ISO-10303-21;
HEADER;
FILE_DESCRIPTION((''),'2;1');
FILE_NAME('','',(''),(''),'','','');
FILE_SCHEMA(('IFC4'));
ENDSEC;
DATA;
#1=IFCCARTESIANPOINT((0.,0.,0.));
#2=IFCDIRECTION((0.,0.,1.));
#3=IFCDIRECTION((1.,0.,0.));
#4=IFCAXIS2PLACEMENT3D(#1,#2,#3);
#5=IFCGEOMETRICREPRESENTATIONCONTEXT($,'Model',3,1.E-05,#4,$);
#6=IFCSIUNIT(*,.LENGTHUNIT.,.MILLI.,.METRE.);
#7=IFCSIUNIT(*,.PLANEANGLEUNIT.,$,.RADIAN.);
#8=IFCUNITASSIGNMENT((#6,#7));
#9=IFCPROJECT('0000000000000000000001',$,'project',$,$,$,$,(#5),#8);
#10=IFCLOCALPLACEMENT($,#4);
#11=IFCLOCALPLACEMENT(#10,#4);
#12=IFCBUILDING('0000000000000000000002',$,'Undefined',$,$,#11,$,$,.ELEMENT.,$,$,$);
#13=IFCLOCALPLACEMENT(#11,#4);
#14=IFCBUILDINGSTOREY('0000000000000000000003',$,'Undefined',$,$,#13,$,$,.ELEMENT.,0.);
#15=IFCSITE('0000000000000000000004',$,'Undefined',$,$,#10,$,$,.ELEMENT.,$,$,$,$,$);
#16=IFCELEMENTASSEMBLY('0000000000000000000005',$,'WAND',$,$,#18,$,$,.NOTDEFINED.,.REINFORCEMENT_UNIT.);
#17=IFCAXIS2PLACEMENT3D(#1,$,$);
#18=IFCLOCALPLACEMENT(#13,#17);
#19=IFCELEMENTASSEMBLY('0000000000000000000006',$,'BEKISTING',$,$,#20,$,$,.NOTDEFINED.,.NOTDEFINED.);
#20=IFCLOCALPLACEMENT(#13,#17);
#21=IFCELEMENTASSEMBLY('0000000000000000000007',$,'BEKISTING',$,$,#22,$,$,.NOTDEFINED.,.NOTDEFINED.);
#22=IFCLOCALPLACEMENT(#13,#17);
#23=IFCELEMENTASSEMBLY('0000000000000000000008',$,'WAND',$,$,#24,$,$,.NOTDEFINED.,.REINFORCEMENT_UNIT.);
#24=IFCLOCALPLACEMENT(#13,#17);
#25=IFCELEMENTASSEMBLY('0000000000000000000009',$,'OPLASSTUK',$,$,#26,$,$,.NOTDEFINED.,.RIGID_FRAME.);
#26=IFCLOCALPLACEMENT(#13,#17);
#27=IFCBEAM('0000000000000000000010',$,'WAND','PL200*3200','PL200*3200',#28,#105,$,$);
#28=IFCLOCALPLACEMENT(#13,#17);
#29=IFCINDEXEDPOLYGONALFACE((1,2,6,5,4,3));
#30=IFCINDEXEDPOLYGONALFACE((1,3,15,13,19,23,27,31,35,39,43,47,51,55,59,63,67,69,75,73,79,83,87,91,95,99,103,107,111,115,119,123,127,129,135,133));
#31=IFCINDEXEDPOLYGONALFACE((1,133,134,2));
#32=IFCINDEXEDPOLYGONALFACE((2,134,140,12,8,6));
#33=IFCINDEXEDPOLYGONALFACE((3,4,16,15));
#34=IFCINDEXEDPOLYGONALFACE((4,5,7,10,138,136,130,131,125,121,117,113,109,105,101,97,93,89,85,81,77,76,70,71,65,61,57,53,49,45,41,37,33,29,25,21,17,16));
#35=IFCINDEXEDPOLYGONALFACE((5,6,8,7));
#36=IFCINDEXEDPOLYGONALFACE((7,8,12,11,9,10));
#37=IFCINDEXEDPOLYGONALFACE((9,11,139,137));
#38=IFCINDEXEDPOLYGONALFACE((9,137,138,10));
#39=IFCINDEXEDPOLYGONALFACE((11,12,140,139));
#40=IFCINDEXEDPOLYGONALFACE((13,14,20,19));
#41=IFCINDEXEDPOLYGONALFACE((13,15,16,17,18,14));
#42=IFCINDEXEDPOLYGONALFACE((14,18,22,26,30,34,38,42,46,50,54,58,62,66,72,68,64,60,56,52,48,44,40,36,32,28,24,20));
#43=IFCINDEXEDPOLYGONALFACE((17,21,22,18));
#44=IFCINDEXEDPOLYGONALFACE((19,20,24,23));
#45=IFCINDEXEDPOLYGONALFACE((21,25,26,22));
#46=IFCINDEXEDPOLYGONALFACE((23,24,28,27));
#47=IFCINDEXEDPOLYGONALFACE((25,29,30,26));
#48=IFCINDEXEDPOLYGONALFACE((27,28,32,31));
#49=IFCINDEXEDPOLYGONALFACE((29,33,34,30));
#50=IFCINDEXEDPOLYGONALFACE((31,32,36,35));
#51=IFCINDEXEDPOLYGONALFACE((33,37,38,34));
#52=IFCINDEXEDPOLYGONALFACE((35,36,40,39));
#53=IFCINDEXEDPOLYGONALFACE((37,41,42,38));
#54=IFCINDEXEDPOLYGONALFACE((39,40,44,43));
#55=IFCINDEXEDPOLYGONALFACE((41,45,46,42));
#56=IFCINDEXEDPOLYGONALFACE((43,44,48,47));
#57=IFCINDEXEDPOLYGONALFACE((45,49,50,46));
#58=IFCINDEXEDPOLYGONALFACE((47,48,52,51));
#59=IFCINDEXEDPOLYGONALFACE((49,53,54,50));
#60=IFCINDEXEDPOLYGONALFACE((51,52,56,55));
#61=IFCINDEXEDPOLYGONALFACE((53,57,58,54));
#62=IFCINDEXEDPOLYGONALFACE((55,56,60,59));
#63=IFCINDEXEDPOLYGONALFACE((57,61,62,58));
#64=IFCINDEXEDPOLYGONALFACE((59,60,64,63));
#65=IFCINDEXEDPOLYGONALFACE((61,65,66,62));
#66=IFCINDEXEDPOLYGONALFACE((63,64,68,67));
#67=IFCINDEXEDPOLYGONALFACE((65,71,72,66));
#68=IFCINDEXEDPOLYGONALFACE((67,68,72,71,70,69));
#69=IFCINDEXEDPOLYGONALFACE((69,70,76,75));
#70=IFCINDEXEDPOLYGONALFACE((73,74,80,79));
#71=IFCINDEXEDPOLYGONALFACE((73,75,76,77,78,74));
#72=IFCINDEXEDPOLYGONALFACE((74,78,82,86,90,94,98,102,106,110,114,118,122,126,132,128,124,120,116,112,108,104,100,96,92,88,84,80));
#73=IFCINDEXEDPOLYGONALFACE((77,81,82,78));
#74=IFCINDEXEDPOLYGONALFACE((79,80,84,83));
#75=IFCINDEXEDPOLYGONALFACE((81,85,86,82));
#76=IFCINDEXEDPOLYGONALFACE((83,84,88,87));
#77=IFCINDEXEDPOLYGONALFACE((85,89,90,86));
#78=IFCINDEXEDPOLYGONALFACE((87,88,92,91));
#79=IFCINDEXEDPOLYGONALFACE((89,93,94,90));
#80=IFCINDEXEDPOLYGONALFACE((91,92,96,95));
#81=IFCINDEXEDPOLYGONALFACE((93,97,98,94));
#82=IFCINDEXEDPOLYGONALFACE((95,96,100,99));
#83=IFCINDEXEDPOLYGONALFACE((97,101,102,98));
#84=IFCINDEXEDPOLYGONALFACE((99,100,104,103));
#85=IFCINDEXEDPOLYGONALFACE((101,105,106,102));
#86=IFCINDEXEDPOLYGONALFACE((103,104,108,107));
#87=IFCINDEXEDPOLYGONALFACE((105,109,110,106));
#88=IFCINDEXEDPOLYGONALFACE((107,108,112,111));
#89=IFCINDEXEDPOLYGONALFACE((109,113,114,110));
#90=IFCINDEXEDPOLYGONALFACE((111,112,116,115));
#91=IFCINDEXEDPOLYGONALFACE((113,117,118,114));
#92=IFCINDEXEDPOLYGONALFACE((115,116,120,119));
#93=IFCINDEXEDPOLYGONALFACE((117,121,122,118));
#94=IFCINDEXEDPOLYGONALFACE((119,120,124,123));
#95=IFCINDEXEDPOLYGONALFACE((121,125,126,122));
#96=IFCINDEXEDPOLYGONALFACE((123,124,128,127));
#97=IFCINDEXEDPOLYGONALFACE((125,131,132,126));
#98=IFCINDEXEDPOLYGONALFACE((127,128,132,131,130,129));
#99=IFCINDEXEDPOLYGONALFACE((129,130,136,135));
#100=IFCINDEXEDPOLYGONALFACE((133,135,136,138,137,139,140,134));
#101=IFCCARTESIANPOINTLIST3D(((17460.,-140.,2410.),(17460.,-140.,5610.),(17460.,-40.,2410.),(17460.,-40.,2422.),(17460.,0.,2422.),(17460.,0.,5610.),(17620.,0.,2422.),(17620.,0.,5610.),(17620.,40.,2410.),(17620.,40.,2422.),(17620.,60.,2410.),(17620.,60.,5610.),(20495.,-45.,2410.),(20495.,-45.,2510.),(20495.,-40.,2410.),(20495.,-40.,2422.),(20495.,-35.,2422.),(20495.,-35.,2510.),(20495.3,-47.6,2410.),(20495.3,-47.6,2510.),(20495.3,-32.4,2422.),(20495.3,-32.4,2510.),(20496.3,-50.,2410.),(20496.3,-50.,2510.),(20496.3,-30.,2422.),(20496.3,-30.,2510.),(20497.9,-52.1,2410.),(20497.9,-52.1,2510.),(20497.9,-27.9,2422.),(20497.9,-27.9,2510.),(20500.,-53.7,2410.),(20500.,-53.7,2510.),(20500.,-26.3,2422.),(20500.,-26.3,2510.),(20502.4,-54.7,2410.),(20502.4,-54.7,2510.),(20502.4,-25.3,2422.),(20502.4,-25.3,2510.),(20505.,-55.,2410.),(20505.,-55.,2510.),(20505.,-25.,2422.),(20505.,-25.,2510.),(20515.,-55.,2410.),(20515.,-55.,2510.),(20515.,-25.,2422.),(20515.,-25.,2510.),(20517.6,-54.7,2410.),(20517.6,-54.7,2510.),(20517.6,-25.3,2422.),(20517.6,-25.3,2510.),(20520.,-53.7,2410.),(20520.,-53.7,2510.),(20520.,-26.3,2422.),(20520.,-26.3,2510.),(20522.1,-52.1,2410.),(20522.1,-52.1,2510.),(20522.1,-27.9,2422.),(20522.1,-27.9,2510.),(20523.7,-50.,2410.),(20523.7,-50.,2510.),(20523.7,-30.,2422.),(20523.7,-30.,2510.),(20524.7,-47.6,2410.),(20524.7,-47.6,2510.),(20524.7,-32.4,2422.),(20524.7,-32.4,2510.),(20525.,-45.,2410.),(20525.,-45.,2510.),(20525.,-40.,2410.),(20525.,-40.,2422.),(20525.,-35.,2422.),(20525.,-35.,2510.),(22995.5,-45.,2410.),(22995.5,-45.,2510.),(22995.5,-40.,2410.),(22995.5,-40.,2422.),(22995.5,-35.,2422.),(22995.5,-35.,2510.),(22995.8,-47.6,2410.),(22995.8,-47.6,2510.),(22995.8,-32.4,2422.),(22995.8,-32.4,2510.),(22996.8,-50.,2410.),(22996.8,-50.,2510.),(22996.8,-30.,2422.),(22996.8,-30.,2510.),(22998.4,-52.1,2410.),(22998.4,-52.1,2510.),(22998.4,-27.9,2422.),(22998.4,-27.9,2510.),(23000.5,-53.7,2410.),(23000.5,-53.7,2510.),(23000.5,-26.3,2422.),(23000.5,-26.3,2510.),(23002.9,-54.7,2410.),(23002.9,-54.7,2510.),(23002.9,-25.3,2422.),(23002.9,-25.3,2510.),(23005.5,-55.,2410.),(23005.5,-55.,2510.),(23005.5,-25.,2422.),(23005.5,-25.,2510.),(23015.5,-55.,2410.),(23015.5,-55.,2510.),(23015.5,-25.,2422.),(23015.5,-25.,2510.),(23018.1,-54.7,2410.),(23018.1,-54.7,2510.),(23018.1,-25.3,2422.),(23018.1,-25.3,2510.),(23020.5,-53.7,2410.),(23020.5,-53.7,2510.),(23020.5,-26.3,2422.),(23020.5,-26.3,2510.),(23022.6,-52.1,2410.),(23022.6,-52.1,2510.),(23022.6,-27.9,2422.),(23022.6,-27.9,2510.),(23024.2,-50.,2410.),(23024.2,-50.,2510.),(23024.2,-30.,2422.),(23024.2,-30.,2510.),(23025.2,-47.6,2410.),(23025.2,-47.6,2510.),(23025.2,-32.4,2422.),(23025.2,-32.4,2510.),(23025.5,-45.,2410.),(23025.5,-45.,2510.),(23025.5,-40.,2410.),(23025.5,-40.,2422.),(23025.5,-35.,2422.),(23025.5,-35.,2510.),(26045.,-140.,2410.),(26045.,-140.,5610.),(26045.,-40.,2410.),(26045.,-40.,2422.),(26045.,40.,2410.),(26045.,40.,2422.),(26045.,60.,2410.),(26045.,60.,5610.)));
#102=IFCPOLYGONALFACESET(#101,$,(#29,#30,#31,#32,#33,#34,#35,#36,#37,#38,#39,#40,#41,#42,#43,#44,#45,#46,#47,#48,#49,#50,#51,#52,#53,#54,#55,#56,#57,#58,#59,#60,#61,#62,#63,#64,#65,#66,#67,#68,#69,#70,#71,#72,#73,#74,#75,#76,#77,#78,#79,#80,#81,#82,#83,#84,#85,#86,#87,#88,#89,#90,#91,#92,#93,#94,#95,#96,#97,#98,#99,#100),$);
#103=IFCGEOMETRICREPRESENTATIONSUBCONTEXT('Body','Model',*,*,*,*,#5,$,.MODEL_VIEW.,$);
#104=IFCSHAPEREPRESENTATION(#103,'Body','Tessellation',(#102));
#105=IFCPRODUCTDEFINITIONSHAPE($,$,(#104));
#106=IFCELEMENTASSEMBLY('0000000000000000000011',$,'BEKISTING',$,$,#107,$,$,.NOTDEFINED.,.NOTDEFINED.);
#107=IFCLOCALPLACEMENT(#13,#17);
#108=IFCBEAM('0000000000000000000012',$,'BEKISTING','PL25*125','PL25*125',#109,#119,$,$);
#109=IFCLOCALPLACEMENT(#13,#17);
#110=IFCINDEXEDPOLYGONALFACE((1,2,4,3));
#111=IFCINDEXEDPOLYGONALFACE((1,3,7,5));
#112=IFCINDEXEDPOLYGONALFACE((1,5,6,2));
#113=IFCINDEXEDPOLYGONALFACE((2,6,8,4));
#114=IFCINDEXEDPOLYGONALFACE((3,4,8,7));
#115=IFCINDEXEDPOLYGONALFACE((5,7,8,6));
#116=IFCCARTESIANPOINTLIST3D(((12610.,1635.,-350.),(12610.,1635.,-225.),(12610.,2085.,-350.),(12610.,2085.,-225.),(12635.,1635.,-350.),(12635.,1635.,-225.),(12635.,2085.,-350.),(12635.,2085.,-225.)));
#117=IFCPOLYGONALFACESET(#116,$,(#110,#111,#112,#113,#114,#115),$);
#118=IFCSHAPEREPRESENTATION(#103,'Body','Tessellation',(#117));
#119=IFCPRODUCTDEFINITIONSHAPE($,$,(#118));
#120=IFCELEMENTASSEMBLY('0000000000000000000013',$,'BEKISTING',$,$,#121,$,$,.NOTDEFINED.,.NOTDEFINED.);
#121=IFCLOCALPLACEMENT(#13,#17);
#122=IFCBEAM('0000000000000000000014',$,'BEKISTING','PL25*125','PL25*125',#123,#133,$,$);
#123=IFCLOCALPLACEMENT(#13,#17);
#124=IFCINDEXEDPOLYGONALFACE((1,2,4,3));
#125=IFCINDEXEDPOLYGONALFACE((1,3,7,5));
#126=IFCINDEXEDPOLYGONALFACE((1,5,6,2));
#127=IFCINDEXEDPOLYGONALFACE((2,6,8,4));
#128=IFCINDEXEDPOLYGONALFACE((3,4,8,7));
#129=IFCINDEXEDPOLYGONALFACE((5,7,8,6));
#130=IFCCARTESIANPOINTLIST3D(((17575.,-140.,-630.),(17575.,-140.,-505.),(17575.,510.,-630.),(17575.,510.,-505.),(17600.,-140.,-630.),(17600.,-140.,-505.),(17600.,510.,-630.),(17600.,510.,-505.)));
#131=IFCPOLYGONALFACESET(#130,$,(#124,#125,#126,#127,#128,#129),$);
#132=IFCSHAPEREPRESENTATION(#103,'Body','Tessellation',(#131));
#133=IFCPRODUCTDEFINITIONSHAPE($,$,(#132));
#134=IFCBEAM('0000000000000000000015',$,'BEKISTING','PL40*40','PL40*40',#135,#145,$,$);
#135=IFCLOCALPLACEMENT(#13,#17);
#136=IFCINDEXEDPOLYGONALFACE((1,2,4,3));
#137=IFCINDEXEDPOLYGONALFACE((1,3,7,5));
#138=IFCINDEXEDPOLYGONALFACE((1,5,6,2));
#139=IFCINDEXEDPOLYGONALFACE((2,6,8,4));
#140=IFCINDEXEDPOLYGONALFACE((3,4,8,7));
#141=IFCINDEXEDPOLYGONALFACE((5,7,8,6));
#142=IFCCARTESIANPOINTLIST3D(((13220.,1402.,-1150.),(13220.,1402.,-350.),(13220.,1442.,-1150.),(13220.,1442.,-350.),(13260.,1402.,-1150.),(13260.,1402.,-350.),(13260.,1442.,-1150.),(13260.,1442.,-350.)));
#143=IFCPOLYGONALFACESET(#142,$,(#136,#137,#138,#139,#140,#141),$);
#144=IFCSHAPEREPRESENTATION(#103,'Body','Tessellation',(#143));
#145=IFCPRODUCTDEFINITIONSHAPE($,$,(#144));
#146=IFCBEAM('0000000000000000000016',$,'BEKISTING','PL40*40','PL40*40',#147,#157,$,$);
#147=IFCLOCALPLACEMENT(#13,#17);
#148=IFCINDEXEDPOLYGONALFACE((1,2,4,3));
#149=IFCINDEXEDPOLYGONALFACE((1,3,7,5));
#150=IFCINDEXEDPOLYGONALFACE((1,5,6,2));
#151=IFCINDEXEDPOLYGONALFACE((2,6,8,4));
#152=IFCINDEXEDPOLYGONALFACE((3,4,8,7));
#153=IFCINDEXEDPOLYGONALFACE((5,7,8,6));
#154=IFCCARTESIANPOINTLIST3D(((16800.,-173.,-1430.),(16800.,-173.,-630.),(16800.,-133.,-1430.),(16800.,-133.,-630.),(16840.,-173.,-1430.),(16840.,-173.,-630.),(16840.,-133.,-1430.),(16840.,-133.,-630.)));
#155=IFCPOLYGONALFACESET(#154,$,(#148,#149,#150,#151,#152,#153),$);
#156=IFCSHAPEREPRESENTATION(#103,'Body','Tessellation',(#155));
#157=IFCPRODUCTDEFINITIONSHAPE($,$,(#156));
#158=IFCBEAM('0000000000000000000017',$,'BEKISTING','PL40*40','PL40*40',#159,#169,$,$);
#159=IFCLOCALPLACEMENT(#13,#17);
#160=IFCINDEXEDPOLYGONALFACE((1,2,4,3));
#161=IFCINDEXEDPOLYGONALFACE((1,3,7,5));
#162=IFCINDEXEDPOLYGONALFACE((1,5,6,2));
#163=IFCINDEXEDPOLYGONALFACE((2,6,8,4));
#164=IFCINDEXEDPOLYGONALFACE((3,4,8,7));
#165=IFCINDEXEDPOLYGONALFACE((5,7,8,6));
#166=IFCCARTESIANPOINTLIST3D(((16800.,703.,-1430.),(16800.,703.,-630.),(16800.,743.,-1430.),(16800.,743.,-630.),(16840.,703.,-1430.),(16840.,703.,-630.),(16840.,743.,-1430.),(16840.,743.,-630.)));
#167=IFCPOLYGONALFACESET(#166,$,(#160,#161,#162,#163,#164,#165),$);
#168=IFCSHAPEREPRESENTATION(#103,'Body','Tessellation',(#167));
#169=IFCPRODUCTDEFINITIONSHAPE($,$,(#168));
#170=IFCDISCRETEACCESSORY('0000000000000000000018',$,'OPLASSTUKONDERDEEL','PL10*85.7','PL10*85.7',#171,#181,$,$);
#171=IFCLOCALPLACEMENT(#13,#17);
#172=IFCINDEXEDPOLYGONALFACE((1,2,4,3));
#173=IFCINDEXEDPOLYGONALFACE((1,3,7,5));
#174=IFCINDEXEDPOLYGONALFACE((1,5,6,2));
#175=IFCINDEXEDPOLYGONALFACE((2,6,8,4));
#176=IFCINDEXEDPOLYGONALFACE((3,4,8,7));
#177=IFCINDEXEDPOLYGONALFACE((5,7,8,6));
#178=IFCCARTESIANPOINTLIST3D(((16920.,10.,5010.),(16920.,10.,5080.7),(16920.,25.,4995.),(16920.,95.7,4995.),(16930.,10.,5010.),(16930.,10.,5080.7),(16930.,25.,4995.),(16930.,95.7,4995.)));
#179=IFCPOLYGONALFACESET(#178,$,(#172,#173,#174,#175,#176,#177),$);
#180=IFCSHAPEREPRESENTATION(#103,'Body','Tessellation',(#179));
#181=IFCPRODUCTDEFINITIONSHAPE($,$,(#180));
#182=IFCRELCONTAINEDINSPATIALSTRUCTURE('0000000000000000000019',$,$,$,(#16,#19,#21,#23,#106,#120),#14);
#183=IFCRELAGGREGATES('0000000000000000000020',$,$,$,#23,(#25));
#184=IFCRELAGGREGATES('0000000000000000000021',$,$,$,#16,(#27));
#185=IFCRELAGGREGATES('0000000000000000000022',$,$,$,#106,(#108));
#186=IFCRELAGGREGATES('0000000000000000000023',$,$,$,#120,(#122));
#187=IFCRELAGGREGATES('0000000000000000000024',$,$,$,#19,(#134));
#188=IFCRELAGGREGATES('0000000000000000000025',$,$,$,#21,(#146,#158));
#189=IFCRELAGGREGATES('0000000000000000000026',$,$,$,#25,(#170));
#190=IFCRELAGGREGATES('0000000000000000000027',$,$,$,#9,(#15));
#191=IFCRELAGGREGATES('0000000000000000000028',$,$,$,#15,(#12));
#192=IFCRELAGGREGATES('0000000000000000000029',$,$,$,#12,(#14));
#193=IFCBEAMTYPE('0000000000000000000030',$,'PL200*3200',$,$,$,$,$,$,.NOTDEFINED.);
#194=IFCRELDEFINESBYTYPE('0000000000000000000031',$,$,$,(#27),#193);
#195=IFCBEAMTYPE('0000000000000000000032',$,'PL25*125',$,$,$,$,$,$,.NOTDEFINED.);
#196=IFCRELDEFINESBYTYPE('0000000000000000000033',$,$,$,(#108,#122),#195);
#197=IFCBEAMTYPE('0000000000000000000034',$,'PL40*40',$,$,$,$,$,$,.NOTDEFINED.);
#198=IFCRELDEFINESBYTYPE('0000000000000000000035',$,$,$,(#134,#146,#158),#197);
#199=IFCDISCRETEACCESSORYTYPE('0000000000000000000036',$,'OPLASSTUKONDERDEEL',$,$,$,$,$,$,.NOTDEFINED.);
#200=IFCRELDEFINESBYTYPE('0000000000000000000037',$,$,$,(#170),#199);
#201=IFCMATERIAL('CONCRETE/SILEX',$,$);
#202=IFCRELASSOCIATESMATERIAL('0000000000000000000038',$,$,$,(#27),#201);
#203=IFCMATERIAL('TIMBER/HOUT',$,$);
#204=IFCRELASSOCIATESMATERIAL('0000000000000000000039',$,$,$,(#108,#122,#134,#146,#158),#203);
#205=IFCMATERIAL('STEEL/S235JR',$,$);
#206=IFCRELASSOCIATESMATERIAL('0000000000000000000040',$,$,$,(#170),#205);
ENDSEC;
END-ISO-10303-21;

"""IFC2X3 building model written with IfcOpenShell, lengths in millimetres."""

from ifc_helpers import new_model, si_unit, frame, frame_2d, origin_with_axes, place, context, subcontext, project, spatial, polyline, circle_curve, parameter, trimmed, segment, composite_curve, rectangle, outline, extrude, boolean, material, type_object, element, aggregate, save


model = new_model("IFC2X3")

# Units and contexts
model_context = context("Model", 3, precision=1e-05, world=origin_with_axes())
body_context = subcontext(model_context, "Body", "Model", "MODEL_VIEW")
ifc_project = project(units=[si_unit("LENGTHUNIT", "METRE", prefix="MILLI"), si_unit("PLANEANGLEUNIT", "RADIAN")], contexts=[model_context])

# Site, building, storey
site_placement = place(None, origin_with_axes())
site = spatial("IfcSite", under=ifc_project, at=site_placement, Name="Undefined", CompositionType="ELEMENT")
building_placement = place(site_placement, origin_with_axes())
building = spatial("IfcBuilding", under=site, at=building_placement, Name="Undefined", CompositionType="ELEMENT")
storey_placement = place(building_placement, origin_with_axes())
storey = spatial("IfcBuildingStorey", under=building, at=storey_placement, Name="Undefined", CompositionType="ELEMENT", Elevation=0.0)

# Shared definitions
ifc_material_1 = material(Name="CONCRETE/SILEX")

# Element assembly
assembly_1_placement = place(storey_placement, origin_with_axes())
assembly_1 = element("IfcElementAssembly", 1, at=assembly_1_placement, inside=storey, Name="WAND", AssemblyPlace="NOTDEFINED", PredefinedType="REINFORCEMENT_UNIT")

# Element assemblies
ifc_material_2 = material(Name="STEEL/S235JR")
assembly_2_placement = place(storey_placement, origin_with_axes())
assembly_2 = element("IfcElementAssembly", 2, at=assembly_2_placement, inside=storey, Name="BEKISTING", AssemblyPlace="NOTDEFINED", PredefinedType="NOTDEFINED")
ifc_material_3 = material(Name="TIMBER/HOUT")
assembly_3_placement = place(storey_placement, origin_with_axes())
assembly_3 = element("IfcElementAssembly", 3, at=assembly_3_placement, inside=storey, Name="BEKISTING", AssemblyPlace="NOTDEFINED", PredefinedType="NOTDEFINED")

# Element assemblies
assembly_4_placement = place(storey_placement, origin_with_axes())
assembly_4 = element("IfcElementAssembly", 4, at=assembly_4_placement, inside=storey, Name="WAND", AssemblyPlace="NOTDEFINED", PredefinedType="REINFORCEMENT_UNIT")
assembly_5_placement = place(assembly_4_placement, origin_with_axes())
assembly_5 = element("IfcElementAssembly", 5, at=assembly_5_placement, Name="OPLASSTUK", AssemblyPlace="NOTDEFINED", PredefinedType="RIGID_FRAME")
aggregate(assembly_4, [assembly_5])

# Beam
beam_type_1 = type_object("IfcBeamType", Name="PL200*3200", PredefinedType="NOTDEFINED")
beam_1_placement = place(assembly_1_placement, frame((17460.0, -40.0, 4010.0), z_axis=(0.0, 0.0, 1.0), x_axis=(1.0, 0.0, 0.0)))
beam_1 = element("IfcBeam", 6, at=beam_1_placement, type_object=beam_type_1, material=ifc_material_1, Name="WAND", Description="PL200*3200", ObjectType="PL200*3200", context=body_context, shape_type="CSG", body=[
    boolean("DIFFERENCE", boolean("DIFFERENCE", boolean("DIFFERENCE", boolean("DIFFERENCE", extrude(rectangle(XDim=200.0, YDim=3200.0, at=frame_2d((0.0, 0.0), x_axis=(1.0, 0.0))), frame((8585.0, 0.0, 0.0), z_axis=(-1.0, 0.0, 0.0), x_axis=(0.0, -1.0, 0.0)), (0.0, 0.0, 1.0), 8585.0), extrude(outline(composite_curve([segment(trimmed(circle_curve(frame_2d((10.0, 10.0), x_axis=(-1.0, 0.0)), 10.0), [parameter(0.0)], [parameter(1.570796)], True, "PARAMETER"), True, "CONTINUOUS"), segment(polyline([(10.0, 0.0), (20.0, 0.0)]), True, "CONTINUOUS"), segment(trimmed(circle_curve(frame_2d((20.0, 10.0), x_axis=(0.0, -1.0)), 10.0), [parameter(0.0)], [parameter(1.570796)], True, "PARAMETER"), True, "CONTINUOUS"), segment(polyline([(30.0, 10.0), (30.0, 20.0)]), True, "CONTINUOUS"), segment(trimmed(circle_curve(frame_2d((20.0, 20.0), x_axis=(1.0, 0.0)), 10.0), [parameter(0.0)], [parameter(1.570796)], True, "PARAMETER"), True, "CONTINUOUS"), segment(polyline([(20.0, 30.0), (10.0, 30.0)]), True, "CONTINUOUS"), segment(trimmed(circle_curve(frame_2d((10.0, 20.0), x_axis=(0.0, 1.0)), 10.0), [parameter(0.0)], [parameter(1.570796)], True, "PARAMETER"), True, "CONTINUOUS"), segment(polyline([(0.0, 20.0), (0.0, 10.0)]), True, "CONTINUOUS")], self_intersect=True)), frame((3035.0, 15.0, -1600.0), z_axis=(0.0, 0.0, 1.0), x_axis=(0.0, -1.0, 0.0)), (0.0, 0.0, 1.0), 100.0)), extrude(outline(composite_curve([segment(trimmed(circle_curve(frame_2d((10.0, 10.0), x_axis=(-1.0, 0.0)), 10.0), [parameter(0.0)], [parameter(1.570796)], True, "PARAMETER"), True, "CONTINUOUS"), segment(polyline([(10.0, 0.0), (20.0, 0.0)]), True, "CONTINUOUS"), segment(trimmed(circle_curve(frame_2d((20.0, 10.0), x_axis=(0.0, -1.0)), 10.0), [parameter(0.0)], [parameter(1.570796)], True, "PARAMETER"), True, "CONTINUOUS"), segment(polyline([(30.0, 10.0), (30.0, 20.0)]), True, "CONTINUOUS"), segment(trimmed(circle_curve(frame_2d((20.0, 20.0), x_axis=(1.0, 0.0)), 10.0), [parameter(0.0)], [parameter(1.570796)], True, "PARAMETER"), True, "CONTINUOUS"), segment(polyline([(20.0, 30.0), (10.0, 30.0)]), True, "CONTINUOUS"), segment(trimmed(circle_curve(frame_2d((10.0, 20.0), x_axis=(0.0, 1.0)), 10.0), [parameter(0.0)], [parameter(1.570796)], True, "PARAMETER"), True, "CONTINUOUS"), segment(polyline([(0.0, 20.0), (0.0, 10.0)]), True, "CONTINUOUS")], self_intersect=True)), frame((5565.5, -15.0, -1600.0), z_axis=(0.0, 0.0, 1.0), x_axis=(0.0, 1.0, 0.0)), (0.0, 0.0, 1.0), 100.0)), extrude(outline(polyline([(0.0, 0.0), (60.0, 0.0), (60.0, 185.3), (0.0, 185.3), (0.0, 0.0)])), frame((160.0, 100.0, 1603.0), z_axis=(0.0, 0.0, -1.0), x_axis=(0.0, -1.0, 0.0)), (0.0, 0.0, 1.0), 3205.0)), extrude(rectangle(XDim=12.0, YDim=80.0, at=frame_2d((0.0, 0.0), x_axis=(1.0, 0.0))), frame((8585.0, 40.0, -1594.0), z_axis=(-1.0, 0.0, 0.0), x_axis=(0.0, 0.0, -1.0)), (0.0, 0.0, 1.0), 8585.0)),
])
aggregate(assembly_1, [beam_1])

# Element assemblies, beams
assembly_6_placement = place(storey_placement, origin_with_axes())
assembly_6 = element("IfcElementAssembly", 7, at=assembly_6_placement, inside=storey, Name="BEKISTING", AssemblyPlace="NOTDEFINED", PredefinedType="NOTDEFINED")
beam_type_2 = type_object("IfcBeamType", Name="PL25*125", PredefinedType="NOTDEFINED")
beam_2_placement = place(assembly_6_placement, frame((12622.5, 1635.0, -287.5), z_axis=(0.0, 0.0, 1.0), x_axis=(0.0, 1.0, 0.0)))
beam_2 = element("IfcBeam", 8, at=beam_2_placement, type_object=beam_type_2, material=ifc_material_3, Name="BEKISTING", Description="PL25*125", ObjectType="PL25*125", context=body_context, shape_type="SweptSolid", body=[
    extrude(rectangle(XDim=25.0, YDim=125.0, at=frame_2d((0.0, 0.0), x_axis=(1.0, 0.0))), frame((450.0, 0.0, 0.0), z_axis=(-1.0, 0.0, 0.0), x_axis=(0.0, -1.0, 0.0)), (0.0, 0.0, 1.0), 450.0),
])
aggregate(assembly_6, [beam_2])
assembly_7_placement = place(storey_placement, origin_with_axes())
assembly_7 = element("IfcElementAssembly", 9, at=assembly_7_placement, inside=storey, Name="BEKISTING", AssemblyPlace="NOTDEFINED", PredefinedType="NOTDEFINED")
beam_3_placement = place(assembly_7_placement, frame((17587.5, -140.0, -567.5), z_axis=(0.0, 0.0, -1.0), x_axis=(0.0, 1.0, 0.0)))
beam_3 = element("IfcBeam", 10, at=beam_3_placement, type_object=beam_type_2, material=ifc_material_3, Name="BEKISTING", Description="PL25*125", ObjectType="PL25*125", context=body_context, shape_type="SweptSolid", body=[
    extrude(rectangle(XDim=25.0, YDim=125.0, at=frame_2d((0.0, 0.0), x_axis=(1.0, 0.0))), frame((650.0, 0.0, 0.0), z_axis=(-1.0, 0.0, 0.0), x_axis=(0.0, -1.0, 0.0)), (0.0, 0.0, 1.0), 650.0),
])
aggregate(assembly_7, [beam_3])

# Beams
beam_type_3 = type_object("IfcBeamType", Name="PL40*40", PredefinedType="NOTDEFINED")
beam_4_placement = place(assembly_2_placement, frame((13240.0, 1422.0, -1150.0), z_axis=(1.0, 0.0, 0.0), x_axis=(0.0, 0.0, 1.0)))
beam_4 = element("IfcBeam", 11, at=beam_4_placement, type_object=beam_type_3, material=ifc_material_3, Name="BEKISTING", Description="PL40*40", ObjectType="PL40*40", context=body_context, shape_type="SweptSolid", body=[
    extrude(rectangle(XDim=40.0, YDim=40.0, at=frame_2d((0.0, 0.0), x_axis=(1.0, 0.0))), frame((800.0, 0.0, 0.0), z_axis=(-1.0, 0.0, 0.0), x_axis=(0.0, -1.0, 0.0)), (0.0, 0.0, 1.0), 800.0),
])
aggregate(assembly_2, [beam_4])
beam_5_placement = place(assembly_3_placement, frame((16820.0, -153.0, -1430.0), z_axis=(0.0, 1.0, 0.0), x_axis=(0.0, 0.0, 1.0)))
beam_5 = element("IfcBeam", 12, at=beam_5_placement, type_object=beam_type_3, material=ifc_material_3, Name="BEKISTING", Description="PL40*40", ObjectType="PL40*40", context=body_context, shape_type="SweptSolid", body=[
    extrude(rectangle(XDim=40.0, YDim=40.0, at=frame_2d((0.0, 0.0), x_axis=(1.0, 0.0))), frame((800.0, 0.0, 0.0), z_axis=(-1.0, 0.0, 0.0), x_axis=(0.0, -1.0, 0.0)), (0.0, 0.0, 1.0), 800.0),
])
beam_6_placement = place(assembly_3_placement, frame((16820.0, 723.0, -1430.0), z_axis=(0.0, 1.0, 0.0), x_axis=(0.0, 0.0, 1.0)))
beam_6 = element("IfcBeam", 13, at=beam_6_placement, type_object=beam_type_3, material=ifc_material_3, Name="BEKISTING", Description="PL40*40", ObjectType="PL40*40", context=body_context, shape_type="SweptSolid", body=[
    extrude(rectangle(XDim=40.0, YDim=40.0, at=frame_2d((0.0, 0.0), x_axis=(1.0, 0.0))), frame((800.0, 0.0, 0.0), z_axis=(-1.0, 0.0, 0.0), x_axis=(0.0, -1.0, 0.0)), (0.0, 0.0, 1.0), 800.0),
])
aggregate(assembly_3, [beam_5, beam_6])

# Discrete accessory
discrete_accessory_type_1 = type_object("IfcDiscreteAccessoryType", Name="OPLASSTUKONDERDEEL")
discrete_accessory_1_placement = place(assembly_5_placement, frame((16925.0, 10.0, 5080.7), z_axis=(1.0, 0.0, 0.0), x_axis=(0.0, 0.0, -1.0)))
discrete_accessory_1 = element("IfcDiscreteAccessory", 14, at=discrete_accessory_1_placement, type_object=discrete_accessory_type_1, material=ifc_material_2, Name="OPLASSTUKONDERDEEL", Description="PL10*85.7", ObjectType="PL10*85.7", context=body_context, shape_type="SweptSolid", body=[
    extrude(outline(polyline([(0.0, 0.0), (70.7, 0.0), (85.7, 15.0), (85.7, 85.7), (0.0, 0.0)])), frame((0.0, 0.0, -5.0), z_axis=(0.0, 0.0, 1.0), x_axis=(1.0, 0.0, 0.0)), (0.0, 0.0, 1.0), 10.0),
])
aggregate(assembly_5, [discrete_accessory_1])

save(model, "model.ifc")
